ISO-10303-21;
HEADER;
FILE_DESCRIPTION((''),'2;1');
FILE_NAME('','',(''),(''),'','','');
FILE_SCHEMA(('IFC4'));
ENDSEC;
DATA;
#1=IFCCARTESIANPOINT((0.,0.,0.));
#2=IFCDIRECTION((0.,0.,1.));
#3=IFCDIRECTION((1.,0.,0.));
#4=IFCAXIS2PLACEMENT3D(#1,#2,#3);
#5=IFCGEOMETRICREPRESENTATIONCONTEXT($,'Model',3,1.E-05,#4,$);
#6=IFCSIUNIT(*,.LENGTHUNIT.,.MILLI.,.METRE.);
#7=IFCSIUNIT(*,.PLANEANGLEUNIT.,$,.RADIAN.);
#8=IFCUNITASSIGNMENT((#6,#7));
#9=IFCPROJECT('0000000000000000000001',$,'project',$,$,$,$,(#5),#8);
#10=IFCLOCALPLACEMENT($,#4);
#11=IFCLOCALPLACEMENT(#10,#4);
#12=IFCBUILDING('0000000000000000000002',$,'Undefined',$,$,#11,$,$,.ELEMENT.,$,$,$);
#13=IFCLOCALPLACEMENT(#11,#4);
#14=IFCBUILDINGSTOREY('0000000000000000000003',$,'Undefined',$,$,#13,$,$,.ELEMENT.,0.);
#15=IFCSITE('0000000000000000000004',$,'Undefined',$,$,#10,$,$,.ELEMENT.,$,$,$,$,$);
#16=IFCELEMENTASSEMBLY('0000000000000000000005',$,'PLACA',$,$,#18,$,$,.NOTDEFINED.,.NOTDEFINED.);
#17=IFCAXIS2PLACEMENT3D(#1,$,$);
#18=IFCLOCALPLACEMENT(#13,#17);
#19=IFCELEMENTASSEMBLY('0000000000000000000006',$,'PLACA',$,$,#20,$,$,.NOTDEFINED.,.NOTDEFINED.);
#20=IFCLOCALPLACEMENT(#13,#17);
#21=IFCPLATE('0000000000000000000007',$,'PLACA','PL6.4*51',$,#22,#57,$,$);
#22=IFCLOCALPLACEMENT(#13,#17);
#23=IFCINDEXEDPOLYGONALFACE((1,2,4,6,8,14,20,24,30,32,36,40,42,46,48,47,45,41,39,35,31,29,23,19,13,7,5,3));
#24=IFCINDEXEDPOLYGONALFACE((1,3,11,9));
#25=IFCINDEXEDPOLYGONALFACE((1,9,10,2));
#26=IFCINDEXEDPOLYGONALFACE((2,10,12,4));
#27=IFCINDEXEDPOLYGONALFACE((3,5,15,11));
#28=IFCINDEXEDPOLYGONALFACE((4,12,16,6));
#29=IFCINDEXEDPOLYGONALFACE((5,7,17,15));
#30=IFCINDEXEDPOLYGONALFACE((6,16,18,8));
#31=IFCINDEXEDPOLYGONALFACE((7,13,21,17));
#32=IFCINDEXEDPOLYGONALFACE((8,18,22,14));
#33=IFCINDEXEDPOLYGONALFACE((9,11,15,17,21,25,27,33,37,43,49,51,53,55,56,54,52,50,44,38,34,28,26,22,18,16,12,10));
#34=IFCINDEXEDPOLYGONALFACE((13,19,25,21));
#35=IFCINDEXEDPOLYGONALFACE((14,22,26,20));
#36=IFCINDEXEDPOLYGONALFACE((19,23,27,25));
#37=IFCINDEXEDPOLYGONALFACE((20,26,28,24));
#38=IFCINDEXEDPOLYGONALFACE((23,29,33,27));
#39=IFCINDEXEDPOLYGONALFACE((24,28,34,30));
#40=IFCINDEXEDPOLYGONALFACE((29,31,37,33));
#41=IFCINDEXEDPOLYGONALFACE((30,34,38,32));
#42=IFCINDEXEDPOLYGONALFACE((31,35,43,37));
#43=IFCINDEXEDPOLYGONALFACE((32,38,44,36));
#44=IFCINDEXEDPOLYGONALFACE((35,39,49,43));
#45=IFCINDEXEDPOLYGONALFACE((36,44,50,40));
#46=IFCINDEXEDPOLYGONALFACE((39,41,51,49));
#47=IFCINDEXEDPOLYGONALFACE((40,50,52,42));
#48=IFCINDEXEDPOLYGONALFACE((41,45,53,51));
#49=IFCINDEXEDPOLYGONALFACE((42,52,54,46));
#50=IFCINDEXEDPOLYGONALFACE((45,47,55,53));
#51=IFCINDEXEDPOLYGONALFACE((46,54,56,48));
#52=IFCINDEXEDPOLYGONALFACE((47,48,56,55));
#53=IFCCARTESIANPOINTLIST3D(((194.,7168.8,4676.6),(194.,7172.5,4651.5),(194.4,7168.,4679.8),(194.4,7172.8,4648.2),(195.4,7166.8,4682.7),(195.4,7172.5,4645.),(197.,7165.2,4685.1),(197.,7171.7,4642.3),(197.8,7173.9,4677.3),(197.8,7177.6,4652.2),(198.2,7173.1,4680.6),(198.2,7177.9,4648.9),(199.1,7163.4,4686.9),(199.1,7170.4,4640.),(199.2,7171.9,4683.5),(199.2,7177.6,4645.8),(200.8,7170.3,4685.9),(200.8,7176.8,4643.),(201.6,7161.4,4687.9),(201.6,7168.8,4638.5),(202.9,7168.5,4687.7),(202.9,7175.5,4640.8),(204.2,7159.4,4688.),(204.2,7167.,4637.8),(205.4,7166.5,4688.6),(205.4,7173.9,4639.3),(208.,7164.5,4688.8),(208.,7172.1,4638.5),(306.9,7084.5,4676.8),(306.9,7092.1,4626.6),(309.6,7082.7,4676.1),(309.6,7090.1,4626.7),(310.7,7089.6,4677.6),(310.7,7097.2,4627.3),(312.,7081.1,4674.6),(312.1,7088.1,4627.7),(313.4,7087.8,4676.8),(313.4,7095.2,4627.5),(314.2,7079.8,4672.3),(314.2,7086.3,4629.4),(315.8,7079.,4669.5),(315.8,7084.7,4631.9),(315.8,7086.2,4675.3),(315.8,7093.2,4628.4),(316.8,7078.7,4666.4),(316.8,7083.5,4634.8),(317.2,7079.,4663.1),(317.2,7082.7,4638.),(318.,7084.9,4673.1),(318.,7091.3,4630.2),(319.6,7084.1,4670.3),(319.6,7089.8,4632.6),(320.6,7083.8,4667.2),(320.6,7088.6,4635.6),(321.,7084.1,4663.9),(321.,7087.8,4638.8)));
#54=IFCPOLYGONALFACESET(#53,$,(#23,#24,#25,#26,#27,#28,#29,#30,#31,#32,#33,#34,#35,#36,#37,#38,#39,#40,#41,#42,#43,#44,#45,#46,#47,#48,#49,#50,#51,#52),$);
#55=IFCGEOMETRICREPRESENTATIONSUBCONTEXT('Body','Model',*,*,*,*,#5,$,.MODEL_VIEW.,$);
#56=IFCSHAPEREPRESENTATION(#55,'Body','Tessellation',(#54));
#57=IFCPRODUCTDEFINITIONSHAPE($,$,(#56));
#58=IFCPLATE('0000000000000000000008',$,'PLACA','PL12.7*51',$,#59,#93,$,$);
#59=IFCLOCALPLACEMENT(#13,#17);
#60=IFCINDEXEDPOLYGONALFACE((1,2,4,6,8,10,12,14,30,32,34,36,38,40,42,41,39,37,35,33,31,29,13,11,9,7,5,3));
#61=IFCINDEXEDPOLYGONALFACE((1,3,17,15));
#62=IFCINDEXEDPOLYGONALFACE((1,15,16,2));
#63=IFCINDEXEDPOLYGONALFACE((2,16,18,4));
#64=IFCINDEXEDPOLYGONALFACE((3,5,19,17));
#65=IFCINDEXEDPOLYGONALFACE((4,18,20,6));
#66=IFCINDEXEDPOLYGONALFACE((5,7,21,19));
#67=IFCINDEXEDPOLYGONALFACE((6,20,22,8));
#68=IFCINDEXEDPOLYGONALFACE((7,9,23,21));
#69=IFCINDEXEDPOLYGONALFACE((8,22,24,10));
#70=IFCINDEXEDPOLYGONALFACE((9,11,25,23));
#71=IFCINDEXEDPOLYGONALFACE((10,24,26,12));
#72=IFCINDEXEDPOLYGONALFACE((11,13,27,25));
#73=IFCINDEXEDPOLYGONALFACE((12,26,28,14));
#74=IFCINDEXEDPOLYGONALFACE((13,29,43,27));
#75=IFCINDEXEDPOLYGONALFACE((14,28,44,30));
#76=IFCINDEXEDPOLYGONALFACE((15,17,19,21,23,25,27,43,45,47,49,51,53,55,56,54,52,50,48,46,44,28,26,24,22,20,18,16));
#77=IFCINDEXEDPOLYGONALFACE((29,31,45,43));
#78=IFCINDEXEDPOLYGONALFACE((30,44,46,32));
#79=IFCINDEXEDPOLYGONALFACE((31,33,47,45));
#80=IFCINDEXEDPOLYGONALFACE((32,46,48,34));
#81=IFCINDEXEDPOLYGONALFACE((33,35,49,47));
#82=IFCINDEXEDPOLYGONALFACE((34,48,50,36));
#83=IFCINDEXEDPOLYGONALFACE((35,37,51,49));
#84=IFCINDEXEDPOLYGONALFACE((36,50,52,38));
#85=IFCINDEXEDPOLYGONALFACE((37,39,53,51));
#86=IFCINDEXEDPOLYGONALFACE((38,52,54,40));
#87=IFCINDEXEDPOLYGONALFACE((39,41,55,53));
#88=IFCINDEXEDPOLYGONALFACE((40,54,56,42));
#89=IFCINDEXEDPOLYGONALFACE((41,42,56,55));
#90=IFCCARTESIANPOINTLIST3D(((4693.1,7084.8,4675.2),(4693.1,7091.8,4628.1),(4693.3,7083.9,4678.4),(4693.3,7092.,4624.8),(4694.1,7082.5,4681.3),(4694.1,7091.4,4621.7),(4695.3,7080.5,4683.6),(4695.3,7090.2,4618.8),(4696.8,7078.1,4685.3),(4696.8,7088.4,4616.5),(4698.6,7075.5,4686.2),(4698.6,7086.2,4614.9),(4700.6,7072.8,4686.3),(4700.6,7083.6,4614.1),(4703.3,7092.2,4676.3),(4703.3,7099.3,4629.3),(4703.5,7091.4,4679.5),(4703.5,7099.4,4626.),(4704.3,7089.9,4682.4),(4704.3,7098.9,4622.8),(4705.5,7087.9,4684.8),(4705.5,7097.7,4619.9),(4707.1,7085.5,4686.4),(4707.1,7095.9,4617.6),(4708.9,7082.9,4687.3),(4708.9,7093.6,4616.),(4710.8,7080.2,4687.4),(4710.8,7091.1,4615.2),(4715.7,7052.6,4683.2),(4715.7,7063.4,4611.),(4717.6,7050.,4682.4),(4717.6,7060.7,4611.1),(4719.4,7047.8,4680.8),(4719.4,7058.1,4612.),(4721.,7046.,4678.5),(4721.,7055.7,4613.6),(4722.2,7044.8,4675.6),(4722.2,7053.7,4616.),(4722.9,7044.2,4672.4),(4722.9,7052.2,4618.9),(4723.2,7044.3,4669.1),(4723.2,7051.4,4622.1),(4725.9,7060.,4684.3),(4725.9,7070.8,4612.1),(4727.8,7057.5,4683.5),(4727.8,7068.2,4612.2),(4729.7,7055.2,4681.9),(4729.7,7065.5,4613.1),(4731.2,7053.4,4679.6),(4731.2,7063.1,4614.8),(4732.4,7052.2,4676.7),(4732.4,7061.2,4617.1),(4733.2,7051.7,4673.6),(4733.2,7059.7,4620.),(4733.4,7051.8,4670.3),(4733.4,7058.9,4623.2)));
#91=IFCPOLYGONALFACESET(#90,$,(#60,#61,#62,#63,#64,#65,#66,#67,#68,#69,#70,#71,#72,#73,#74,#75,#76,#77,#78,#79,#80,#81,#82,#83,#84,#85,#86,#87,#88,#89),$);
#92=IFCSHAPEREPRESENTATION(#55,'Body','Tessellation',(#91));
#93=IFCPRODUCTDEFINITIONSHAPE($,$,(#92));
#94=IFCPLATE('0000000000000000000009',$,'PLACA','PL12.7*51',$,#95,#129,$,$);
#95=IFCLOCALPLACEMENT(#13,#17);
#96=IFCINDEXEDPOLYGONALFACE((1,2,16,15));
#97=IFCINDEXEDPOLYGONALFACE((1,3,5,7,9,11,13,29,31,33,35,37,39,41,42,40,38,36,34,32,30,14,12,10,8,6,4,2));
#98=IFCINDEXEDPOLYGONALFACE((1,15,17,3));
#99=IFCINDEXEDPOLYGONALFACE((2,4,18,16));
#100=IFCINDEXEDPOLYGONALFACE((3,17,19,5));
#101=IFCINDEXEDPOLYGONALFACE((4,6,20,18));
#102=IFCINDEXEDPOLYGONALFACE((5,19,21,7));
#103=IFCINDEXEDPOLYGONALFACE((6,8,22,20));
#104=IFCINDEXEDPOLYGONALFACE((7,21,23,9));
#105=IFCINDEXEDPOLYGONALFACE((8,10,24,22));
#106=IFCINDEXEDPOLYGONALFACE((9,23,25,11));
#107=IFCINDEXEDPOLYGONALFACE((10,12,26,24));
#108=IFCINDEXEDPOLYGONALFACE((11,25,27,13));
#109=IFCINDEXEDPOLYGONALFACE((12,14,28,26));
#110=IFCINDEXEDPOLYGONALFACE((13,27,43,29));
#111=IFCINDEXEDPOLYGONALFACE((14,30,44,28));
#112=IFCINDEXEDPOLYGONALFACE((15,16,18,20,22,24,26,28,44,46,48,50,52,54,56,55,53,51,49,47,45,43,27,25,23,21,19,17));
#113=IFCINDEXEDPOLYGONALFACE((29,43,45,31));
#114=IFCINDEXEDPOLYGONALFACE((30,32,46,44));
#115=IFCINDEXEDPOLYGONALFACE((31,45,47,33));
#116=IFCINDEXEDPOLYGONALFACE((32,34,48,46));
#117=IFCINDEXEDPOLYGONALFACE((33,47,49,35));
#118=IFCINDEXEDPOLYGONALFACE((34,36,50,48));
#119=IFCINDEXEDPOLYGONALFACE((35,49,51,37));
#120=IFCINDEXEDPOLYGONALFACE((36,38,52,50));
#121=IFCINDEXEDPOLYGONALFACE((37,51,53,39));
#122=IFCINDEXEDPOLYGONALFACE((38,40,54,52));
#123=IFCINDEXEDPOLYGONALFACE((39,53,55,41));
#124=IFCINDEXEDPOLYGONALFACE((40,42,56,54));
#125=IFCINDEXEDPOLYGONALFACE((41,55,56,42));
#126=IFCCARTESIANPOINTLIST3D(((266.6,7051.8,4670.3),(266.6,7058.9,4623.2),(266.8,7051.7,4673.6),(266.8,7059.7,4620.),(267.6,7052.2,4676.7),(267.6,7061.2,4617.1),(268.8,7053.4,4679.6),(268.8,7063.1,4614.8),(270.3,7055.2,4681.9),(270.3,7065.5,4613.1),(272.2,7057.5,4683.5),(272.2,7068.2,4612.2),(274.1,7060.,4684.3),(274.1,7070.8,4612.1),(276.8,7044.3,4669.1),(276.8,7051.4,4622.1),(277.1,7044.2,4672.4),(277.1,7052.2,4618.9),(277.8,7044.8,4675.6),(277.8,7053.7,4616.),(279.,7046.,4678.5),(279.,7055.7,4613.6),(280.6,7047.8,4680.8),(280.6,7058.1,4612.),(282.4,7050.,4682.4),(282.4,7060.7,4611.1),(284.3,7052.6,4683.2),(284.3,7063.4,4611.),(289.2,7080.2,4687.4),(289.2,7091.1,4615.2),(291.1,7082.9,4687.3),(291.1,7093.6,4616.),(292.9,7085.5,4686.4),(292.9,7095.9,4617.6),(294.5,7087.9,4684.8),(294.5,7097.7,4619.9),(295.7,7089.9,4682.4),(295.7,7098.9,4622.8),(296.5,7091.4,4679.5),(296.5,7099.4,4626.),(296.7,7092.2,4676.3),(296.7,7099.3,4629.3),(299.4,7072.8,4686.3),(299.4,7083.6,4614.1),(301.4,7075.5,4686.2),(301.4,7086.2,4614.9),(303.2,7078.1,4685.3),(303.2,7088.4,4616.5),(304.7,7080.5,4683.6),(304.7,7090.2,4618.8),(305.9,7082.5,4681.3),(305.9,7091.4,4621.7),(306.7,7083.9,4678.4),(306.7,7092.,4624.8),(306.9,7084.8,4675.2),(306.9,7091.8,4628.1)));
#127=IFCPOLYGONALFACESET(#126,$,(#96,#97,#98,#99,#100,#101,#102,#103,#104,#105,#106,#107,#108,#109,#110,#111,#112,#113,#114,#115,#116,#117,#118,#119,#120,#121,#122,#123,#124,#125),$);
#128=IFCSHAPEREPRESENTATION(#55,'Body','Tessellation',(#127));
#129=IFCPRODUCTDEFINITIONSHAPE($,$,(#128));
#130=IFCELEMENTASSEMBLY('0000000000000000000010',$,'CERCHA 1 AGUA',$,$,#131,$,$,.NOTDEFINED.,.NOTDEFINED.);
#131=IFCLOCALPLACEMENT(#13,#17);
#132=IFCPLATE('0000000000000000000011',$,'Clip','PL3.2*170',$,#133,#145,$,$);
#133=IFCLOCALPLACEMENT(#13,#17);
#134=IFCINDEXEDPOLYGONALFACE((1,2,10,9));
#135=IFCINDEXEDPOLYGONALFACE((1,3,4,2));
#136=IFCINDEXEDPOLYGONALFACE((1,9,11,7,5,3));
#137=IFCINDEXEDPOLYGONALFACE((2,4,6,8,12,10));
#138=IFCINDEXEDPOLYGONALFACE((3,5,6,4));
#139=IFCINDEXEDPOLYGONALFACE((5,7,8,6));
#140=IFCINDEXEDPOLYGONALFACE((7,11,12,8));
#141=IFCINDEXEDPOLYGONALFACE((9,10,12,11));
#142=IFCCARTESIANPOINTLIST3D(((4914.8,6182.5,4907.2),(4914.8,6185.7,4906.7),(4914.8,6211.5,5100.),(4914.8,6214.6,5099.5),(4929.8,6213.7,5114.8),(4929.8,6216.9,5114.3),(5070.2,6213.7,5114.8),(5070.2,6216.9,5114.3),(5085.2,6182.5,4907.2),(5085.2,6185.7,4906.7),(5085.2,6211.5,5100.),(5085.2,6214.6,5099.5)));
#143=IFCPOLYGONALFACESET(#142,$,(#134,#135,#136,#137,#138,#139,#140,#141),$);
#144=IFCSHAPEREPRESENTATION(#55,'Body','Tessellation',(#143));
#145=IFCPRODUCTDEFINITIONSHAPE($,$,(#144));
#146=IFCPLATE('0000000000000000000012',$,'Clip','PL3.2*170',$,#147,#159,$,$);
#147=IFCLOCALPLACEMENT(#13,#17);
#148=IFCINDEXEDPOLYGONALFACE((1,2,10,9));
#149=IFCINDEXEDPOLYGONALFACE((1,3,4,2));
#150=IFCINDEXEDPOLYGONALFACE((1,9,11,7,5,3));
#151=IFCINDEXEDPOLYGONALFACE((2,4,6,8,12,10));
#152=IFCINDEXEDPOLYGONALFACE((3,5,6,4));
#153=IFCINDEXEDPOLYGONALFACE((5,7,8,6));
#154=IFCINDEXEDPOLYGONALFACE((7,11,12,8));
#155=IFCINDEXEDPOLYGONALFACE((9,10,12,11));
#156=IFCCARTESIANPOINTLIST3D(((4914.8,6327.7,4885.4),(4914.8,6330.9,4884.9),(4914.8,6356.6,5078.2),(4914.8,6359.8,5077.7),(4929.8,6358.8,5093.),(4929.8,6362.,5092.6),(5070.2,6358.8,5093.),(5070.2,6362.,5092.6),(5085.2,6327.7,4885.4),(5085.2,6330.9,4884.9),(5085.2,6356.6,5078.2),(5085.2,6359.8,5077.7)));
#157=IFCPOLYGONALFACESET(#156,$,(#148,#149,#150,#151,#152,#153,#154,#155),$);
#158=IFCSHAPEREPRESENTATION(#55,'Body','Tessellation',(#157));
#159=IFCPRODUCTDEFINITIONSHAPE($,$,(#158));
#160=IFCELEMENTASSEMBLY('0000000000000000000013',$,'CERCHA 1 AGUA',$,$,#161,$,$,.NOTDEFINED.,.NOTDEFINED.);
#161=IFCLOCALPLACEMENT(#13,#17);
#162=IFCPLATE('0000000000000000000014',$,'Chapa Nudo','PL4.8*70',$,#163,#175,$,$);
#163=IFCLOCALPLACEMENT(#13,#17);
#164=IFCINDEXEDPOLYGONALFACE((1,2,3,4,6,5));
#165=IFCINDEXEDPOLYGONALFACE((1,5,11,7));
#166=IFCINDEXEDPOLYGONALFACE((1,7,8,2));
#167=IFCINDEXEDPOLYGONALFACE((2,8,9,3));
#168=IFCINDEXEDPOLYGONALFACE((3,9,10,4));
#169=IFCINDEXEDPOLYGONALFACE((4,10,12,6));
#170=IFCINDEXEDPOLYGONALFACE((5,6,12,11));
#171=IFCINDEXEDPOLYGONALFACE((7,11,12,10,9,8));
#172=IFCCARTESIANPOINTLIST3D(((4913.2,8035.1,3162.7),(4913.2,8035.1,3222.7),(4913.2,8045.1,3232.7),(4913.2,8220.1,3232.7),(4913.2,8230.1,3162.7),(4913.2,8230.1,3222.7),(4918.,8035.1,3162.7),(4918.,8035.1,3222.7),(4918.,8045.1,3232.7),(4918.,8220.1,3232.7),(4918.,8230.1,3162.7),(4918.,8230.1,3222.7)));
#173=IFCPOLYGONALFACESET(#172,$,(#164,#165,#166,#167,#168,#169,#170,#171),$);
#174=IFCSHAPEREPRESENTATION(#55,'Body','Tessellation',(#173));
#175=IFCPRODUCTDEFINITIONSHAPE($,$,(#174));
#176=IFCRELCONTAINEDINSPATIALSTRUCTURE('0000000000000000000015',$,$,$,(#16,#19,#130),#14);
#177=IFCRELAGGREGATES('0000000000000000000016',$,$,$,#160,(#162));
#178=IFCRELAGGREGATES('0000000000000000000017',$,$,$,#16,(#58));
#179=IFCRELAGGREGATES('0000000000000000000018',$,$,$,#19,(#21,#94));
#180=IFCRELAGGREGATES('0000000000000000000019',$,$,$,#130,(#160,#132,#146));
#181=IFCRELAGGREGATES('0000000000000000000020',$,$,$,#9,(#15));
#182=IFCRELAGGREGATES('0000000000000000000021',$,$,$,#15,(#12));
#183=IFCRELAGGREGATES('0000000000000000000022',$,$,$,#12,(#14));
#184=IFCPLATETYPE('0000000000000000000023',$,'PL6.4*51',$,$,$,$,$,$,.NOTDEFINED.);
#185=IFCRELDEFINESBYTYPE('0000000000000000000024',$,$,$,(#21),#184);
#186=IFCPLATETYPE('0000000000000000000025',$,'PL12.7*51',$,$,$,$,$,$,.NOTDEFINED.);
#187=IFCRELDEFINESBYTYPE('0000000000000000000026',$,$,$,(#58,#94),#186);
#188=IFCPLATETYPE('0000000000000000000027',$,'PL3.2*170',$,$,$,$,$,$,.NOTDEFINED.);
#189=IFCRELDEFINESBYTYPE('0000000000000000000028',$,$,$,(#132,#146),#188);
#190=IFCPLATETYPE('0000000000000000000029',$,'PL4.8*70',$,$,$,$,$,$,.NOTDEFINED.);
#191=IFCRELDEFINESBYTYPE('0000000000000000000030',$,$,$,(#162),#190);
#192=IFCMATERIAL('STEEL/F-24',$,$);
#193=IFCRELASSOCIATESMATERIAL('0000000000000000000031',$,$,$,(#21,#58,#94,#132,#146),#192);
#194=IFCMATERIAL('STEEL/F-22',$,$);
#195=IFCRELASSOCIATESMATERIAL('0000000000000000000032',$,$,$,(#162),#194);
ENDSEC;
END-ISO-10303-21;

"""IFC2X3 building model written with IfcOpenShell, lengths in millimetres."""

from ifc_helpers import new_model, si_unit, frame, frame_2d, origin_with_axes, place, context, subcontext, project, spatial, polyline, circle_curve, parameter, trimmed, segment, composite_curve, outline, extrude, material, type_object, element, aggregate, save


model = new_model("IFC2X3")

# Units and contexts
model_context = context("Model", 3, precision=1e-05, world=origin_with_axes())
body_context = subcontext(model_context, "Body", "Model", "MODEL_VIEW")
ifc_project = project(units=[si_unit("LENGTHUNIT", "METRE", prefix="MILLI"), si_unit("PLANEANGLEUNIT", "RADIAN")], contexts=[model_context])

# Site, building, storey
site_placement = place(None, origin_with_axes())
site = spatial("IfcSite", under=ifc_project, at=site_placement, Name="Undefined", CompositionType="ELEMENT")
building_placement = place(site_placement, origin_with_axes())
building = spatial("IfcBuilding", under=site, at=building_placement, Name="Undefined", CompositionType="ELEMENT")
storey_placement = place(building_placement, origin_with_axes())
storey = spatial("IfcBuildingStorey", under=building, at=storey_placement, Name="Undefined", CompositionType="ELEMENT", Elevation=0.0)

# Shared definitions
ifc_material_1 = material(Name="STEEL/F-24")

# Element assemblies, plate
assembly_1_placement = place(storey_placement, origin_with_axes())
assembly_1 = element("IfcElementAssembly", 1, at=assembly_1_placement, inside=storey, Name="PLACA", AssemblyPlace="NOTDEFINED", PredefinedType="NOTDEFINED")
plate_type_1 = type_object("IfcPlateType", Name="PL6.4*51", PredefinedType="NOTDEFINED")
assembly_2_placement = place(storey_placement, origin_with_axes())
assembly_2 = element("IfcElementAssembly", 2, at=assembly_2_placement, inside=storey, Name="PLACA", AssemblyPlace="NOTDEFINED", PredefinedType="NOTDEFINED")
plate_1_placement = place(assembly_2_placement, frame((195.9, 7177.0, 4639.3), z_axis=(0.593392, 0.796009, 0.119399), x_axis=(-0.00003, -0.148316, 0.98894)))
plate_1 = element("IfcPlate", 3, at=plate_1_placement, type_object=plate_type_1, material=ifc_material_1, Name="PLACA", Description="PL6.4*51", context=body_context, shape_type="SweptSolid", body=[
    extrude(outline(composite_curve([segment(trimmed(circle_curve(frame_2d((12.7, 12.7), x_axis=(-1.0, 0.0)), 12.7), [parameter(0.0)], [parameter(1.570796)], True, "PARAMETER"), True, "CONTINUOUS"), segment(polyline([(12.7, 0.0), (38.1, 0.0)]), True, "CONTINUOUS"), segment(trimmed(circle_curve(frame_2d((38.1, 12.7), x_axis=(0.0, -1.0)), 12.7), [parameter(0.0)], [parameter(1.570796)], True, "PARAMETER"), True, "CONTINUOUS"), segment(polyline([(50.8, 12.7), (50.8, 140.3)]), True, "CONTINUOUS"), segment(trimmed(circle_curve(frame_2d((38.1, 140.3), x_axis=(1.0, 0.0)), 12.7), [parameter(0.0)], [parameter(1.570796)], True, "PARAMETER"), True, "CONTINUOUS"), segment(polyline([(38.1, 153.0), (12.7, 153.0)]), True, "CONTINUOUS"), segment(trimmed(circle_curve(frame_2d((12.7, 140.3), x_axis=(0.0, 1.0)), 12.7), [parameter(0.0)], [parameter(1.570796)], True, "PARAMETER"), True, "CONTINUOUS"), segment(polyline([(0.0, 140.3), (0.0, 12.7)]), True, "CONTINUOUS")], self_intersect=True)), frame((0.0, 0.0, -3.2), z_axis=(0.0, 0.0, 1.0), x_axis=(1.0, 0.0, 0.0)), (0.0, 0.0, 1.0), 6.4),
])

# Plates
plate_type_2 = type_object("IfcPlateType", Name="PL12.7*51", PredefinedType="NOTDEFINED")
plate_2_placement = place(assembly_1_placement, frame((4698.2, 7086.6, 4688.3), z_axis=(-0.804914, -0.586833, -0.087985), x_axis=(-0.00003, 0.148316, -0.98894)))
plate_2 = element("IfcPlate", 4, at=plate_2_placement, type_object=plate_type_2, material=ifc_material_1, Name="PLACA", Description="PL12.7*51", context=body_context, shape_type="SweptSolid", body=[
    extrude(outline(composite_curve([segment(trimmed(circle_curve(frame_2d((12.7, 12.7), x_axis=(-1.0, 0.0)), 12.7), [parameter(0.0)], [parameter(1.570796)], True, "PARAMETER"), True, "CONTINUOUS"), segment(polyline([(12.7, 0.0), (60.3, 0.0)]), True, "CONTINUOUS"), segment(trimmed(circle_curve(frame_2d((60.3, 12.7), x_axis=(0.0, -1.0)), 12.7), [parameter(0.0)], [parameter(1.570796)], True, "PARAMETER"), True, "CONTINUOUS"), segment(polyline([(73.0, 12.7), (73.0, 38.1)]), True, "CONTINUOUS"), segment(trimmed(circle_curve(frame_2d((60.3, 38.1), x_axis=(1.0, 0.0)), 12.7), [parameter(0.0)], [parameter(1.570796)], True, "PARAMETER"), True, "CONTINUOUS"), segment(polyline([(60.3, 50.8), (12.7, 50.8)]), True, "CONTINUOUS"), segment(trimmed(circle_curve(frame_2d((12.7, 38.1), x_axis=(0.0, 1.0)), 12.7), [parameter(0.0)], [parameter(1.570796)], True, "PARAMETER"), True, "CONTINUOUS"), segment(polyline([(0.0, 38.1), (0.0, 12.7)]), True, "CONTINUOUS")], self_intersect=True)), frame((0.0, 0.0, -6.3), z_axis=(0.0, 0.0, 1.0), x_axis=(1.0, 0.0, 0.0)), (0.0, 0.0, 1.0), 12.7),
])
plate_3_placement = place(assembly_2_placement, frame((301.8, 7086.6, 4688.3), z_axis=(-0.804914, 0.586833, 0.087985), x_axis=(0.00003, 0.148316, -0.98894)))
plate_3 = element("IfcPlate", 5, at=plate_3_placement, type_object=plate_type_2, material=ifc_material_1, Name="PLACA", Description="PL12.7*51", context=body_context, shape_type="SweptSolid", body=[
    extrude(outline(composite_curve([segment(trimmed(circle_curve(frame_2d((12.7, 12.7), x_axis=(-1.0, 0.0)), 12.7), [parameter(0.0)], [parameter(1.570796)], True, "PARAMETER"), True, "CONTINUOUS"), segment(polyline([(12.7, 0.0), (60.3, 0.0)]), True, "CONTINUOUS"), segment(trimmed(circle_curve(frame_2d((60.3, 12.7), x_axis=(0.0, -1.0)), 12.7), [parameter(0.0)], [parameter(1.570796)], True, "PARAMETER"), True, "CONTINUOUS"), segment(polyline([(73.0, 12.7), (73.0, 38.1)]), True, "CONTINUOUS"), segment(trimmed(circle_curve(frame_2d((60.3, 38.1), x_axis=(1.0, 0.0)), 12.7), [parameter(0.0)], [parameter(1.570796)], True, "PARAMETER"), True, "CONTINUOUS"), segment(polyline([(60.3, 50.8), (12.7, 50.8)]), True, "CONTINUOUS"), segment(trimmed(circle_curve(frame_2d((12.7, 38.1), x_axis=(0.0, 1.0)), 12.7), [parameter(0.0)], [parameter(1.570796)], True, "PARAMETER"), True, "CONTINUOUS"), segment(polyline([(0.0, 38.1), (0.0, 12.7)]), True, "CONTINUOUS")], self_intersect=True)), frame((0.0, 0.0, -6.3), z_axis=(0.0, 0.0, 1.0), x_axis=(1.0, 0.0, 0.0)), (0.0, 0.0, 1.0), 12.7),
])

# Element assembly, plates
assembly_3_placement = place(storey_placement, origin_with_axes())
assembly_3 = element("IfcElementAssembly", 6, at=assembly_3_placement, inside=storey, Name="CERCHA 1 AGUA", AssemblyPlace="NOTDEFINED", PredefinedType="NOTDEFINED")
plate_type_3 = type_object("IfcPlateType", Name="PL3.2*170", PredefinedType="NOTDEFINED")
plate_4_placement = place(assembly_3_placement, frame((4914.8, 6184.1, 4906.9), z_axis=(0.0, -0.988921, 0.148445), x_axis=(1.0, 0.0, 0.0)))
plate_4 = element("IfcPlate", 7, at=plate_4_placement, type_object=plate_type_3, material=ifc_material_1, Name="Clip", Description="PL3.2*170", context=body_context, shape_type="SweptSolid", body=[
    extrude(outline(polyline([(0.0, 0.0), (170.4, 0.0), (170.4, 195.0), (155.4, 210.0), (15.0, 210.0), (0.0, 195.0), (0.0, 0.0)])), frame((0.0, 0.0, -1.6), z_axis=(0.0, 0.0, 1.0), x_axis=(1.0, 0.0, 0.0)), (0.0, 0.0, 1.0), 3.2),
])
plate_5_placement = place(assembly_3_placement, frame((4914.8, 6329.3, 4885.1), z_axis=(0.0, -0.988956, 0.148209), x_axis=(1.0, 0.0, 0.0)))
plate_5 = element("IfcPlate", 8, at=plate_5_placement, type_object=plate_type_3, material=ifc_material_1, Name="Clip", Description="PL3.2*170", context=body_context, shape_type="SweptSolid", body=[
    extrude(outline(polyline([(0.0, 0.0), (170.4, 0.0), (170.4, 195.0), (155.4, 210.0), (15.0, 210.0), (0.0, 195.0), (0.0, 0.0)])), frame((0.0, 0.0, -1.6), z_axis=(0.0, 0.0, 1.0), x_axis=(1.0, 0.0, 0.0)), (0.0, 0.0, 1.0), 3.2),
])

# Element assembly, plate
assembly_4_placement = place(assembly_3_placement, origin_with_axes())
assembly_4 = element("IfcElementAssembly", 9, at=assembly_4_placement, Name="CERCHA 1 AGUA", AssemblyPlace="NOTDEFINED", PredefinedType="NOTDEFINED")
ifc_material_2 = material(Name="STEEL/F-22")
plate_type_4 = type_object("IfcPlateType", Name="PL4.8*70", PredefinedType="NOTDEFINED")
plate_6_placement = place(assembly_4_placement, frame((4915.6, 8230.1, 3232.7), z_axis=(-1.0, 0.0, 0.0), x_axis=(0.0, 0.0, -1.0)))
plate_6 = element("IfcPlate", 10, at=plate_6_placement, type_object=plate_type_4, material=ifc_material_2, Name="Chapa Nudo", Description="PL4.8*70", context=body_context, shape_type="SweptSolid", body=[
    extrude(outline(polyline([(0.0, 10.0), (10.0, 0.0), (70.0, 0.0), (70.0, 195.0), (10.0, 195.0), (0.0, 185.0), (0.0, 10.0)])), frame((0.0, 0.0, -2.4), z_axis=(0.0, 0.0, 1.0), x_axis=(1.0, 0.0, 0.0)), (0.0, 0.0, 1.0), 4.8),
])
aggregate(assembly_4, [plate_6])

aggregate(assembly_1, [plate_2])
aggregate(assembly_2, [plate_1, plate_3])

aggregate(assembly_3, [assembly_4, plate_4, plate_5])

save(model, "model.ifc")
